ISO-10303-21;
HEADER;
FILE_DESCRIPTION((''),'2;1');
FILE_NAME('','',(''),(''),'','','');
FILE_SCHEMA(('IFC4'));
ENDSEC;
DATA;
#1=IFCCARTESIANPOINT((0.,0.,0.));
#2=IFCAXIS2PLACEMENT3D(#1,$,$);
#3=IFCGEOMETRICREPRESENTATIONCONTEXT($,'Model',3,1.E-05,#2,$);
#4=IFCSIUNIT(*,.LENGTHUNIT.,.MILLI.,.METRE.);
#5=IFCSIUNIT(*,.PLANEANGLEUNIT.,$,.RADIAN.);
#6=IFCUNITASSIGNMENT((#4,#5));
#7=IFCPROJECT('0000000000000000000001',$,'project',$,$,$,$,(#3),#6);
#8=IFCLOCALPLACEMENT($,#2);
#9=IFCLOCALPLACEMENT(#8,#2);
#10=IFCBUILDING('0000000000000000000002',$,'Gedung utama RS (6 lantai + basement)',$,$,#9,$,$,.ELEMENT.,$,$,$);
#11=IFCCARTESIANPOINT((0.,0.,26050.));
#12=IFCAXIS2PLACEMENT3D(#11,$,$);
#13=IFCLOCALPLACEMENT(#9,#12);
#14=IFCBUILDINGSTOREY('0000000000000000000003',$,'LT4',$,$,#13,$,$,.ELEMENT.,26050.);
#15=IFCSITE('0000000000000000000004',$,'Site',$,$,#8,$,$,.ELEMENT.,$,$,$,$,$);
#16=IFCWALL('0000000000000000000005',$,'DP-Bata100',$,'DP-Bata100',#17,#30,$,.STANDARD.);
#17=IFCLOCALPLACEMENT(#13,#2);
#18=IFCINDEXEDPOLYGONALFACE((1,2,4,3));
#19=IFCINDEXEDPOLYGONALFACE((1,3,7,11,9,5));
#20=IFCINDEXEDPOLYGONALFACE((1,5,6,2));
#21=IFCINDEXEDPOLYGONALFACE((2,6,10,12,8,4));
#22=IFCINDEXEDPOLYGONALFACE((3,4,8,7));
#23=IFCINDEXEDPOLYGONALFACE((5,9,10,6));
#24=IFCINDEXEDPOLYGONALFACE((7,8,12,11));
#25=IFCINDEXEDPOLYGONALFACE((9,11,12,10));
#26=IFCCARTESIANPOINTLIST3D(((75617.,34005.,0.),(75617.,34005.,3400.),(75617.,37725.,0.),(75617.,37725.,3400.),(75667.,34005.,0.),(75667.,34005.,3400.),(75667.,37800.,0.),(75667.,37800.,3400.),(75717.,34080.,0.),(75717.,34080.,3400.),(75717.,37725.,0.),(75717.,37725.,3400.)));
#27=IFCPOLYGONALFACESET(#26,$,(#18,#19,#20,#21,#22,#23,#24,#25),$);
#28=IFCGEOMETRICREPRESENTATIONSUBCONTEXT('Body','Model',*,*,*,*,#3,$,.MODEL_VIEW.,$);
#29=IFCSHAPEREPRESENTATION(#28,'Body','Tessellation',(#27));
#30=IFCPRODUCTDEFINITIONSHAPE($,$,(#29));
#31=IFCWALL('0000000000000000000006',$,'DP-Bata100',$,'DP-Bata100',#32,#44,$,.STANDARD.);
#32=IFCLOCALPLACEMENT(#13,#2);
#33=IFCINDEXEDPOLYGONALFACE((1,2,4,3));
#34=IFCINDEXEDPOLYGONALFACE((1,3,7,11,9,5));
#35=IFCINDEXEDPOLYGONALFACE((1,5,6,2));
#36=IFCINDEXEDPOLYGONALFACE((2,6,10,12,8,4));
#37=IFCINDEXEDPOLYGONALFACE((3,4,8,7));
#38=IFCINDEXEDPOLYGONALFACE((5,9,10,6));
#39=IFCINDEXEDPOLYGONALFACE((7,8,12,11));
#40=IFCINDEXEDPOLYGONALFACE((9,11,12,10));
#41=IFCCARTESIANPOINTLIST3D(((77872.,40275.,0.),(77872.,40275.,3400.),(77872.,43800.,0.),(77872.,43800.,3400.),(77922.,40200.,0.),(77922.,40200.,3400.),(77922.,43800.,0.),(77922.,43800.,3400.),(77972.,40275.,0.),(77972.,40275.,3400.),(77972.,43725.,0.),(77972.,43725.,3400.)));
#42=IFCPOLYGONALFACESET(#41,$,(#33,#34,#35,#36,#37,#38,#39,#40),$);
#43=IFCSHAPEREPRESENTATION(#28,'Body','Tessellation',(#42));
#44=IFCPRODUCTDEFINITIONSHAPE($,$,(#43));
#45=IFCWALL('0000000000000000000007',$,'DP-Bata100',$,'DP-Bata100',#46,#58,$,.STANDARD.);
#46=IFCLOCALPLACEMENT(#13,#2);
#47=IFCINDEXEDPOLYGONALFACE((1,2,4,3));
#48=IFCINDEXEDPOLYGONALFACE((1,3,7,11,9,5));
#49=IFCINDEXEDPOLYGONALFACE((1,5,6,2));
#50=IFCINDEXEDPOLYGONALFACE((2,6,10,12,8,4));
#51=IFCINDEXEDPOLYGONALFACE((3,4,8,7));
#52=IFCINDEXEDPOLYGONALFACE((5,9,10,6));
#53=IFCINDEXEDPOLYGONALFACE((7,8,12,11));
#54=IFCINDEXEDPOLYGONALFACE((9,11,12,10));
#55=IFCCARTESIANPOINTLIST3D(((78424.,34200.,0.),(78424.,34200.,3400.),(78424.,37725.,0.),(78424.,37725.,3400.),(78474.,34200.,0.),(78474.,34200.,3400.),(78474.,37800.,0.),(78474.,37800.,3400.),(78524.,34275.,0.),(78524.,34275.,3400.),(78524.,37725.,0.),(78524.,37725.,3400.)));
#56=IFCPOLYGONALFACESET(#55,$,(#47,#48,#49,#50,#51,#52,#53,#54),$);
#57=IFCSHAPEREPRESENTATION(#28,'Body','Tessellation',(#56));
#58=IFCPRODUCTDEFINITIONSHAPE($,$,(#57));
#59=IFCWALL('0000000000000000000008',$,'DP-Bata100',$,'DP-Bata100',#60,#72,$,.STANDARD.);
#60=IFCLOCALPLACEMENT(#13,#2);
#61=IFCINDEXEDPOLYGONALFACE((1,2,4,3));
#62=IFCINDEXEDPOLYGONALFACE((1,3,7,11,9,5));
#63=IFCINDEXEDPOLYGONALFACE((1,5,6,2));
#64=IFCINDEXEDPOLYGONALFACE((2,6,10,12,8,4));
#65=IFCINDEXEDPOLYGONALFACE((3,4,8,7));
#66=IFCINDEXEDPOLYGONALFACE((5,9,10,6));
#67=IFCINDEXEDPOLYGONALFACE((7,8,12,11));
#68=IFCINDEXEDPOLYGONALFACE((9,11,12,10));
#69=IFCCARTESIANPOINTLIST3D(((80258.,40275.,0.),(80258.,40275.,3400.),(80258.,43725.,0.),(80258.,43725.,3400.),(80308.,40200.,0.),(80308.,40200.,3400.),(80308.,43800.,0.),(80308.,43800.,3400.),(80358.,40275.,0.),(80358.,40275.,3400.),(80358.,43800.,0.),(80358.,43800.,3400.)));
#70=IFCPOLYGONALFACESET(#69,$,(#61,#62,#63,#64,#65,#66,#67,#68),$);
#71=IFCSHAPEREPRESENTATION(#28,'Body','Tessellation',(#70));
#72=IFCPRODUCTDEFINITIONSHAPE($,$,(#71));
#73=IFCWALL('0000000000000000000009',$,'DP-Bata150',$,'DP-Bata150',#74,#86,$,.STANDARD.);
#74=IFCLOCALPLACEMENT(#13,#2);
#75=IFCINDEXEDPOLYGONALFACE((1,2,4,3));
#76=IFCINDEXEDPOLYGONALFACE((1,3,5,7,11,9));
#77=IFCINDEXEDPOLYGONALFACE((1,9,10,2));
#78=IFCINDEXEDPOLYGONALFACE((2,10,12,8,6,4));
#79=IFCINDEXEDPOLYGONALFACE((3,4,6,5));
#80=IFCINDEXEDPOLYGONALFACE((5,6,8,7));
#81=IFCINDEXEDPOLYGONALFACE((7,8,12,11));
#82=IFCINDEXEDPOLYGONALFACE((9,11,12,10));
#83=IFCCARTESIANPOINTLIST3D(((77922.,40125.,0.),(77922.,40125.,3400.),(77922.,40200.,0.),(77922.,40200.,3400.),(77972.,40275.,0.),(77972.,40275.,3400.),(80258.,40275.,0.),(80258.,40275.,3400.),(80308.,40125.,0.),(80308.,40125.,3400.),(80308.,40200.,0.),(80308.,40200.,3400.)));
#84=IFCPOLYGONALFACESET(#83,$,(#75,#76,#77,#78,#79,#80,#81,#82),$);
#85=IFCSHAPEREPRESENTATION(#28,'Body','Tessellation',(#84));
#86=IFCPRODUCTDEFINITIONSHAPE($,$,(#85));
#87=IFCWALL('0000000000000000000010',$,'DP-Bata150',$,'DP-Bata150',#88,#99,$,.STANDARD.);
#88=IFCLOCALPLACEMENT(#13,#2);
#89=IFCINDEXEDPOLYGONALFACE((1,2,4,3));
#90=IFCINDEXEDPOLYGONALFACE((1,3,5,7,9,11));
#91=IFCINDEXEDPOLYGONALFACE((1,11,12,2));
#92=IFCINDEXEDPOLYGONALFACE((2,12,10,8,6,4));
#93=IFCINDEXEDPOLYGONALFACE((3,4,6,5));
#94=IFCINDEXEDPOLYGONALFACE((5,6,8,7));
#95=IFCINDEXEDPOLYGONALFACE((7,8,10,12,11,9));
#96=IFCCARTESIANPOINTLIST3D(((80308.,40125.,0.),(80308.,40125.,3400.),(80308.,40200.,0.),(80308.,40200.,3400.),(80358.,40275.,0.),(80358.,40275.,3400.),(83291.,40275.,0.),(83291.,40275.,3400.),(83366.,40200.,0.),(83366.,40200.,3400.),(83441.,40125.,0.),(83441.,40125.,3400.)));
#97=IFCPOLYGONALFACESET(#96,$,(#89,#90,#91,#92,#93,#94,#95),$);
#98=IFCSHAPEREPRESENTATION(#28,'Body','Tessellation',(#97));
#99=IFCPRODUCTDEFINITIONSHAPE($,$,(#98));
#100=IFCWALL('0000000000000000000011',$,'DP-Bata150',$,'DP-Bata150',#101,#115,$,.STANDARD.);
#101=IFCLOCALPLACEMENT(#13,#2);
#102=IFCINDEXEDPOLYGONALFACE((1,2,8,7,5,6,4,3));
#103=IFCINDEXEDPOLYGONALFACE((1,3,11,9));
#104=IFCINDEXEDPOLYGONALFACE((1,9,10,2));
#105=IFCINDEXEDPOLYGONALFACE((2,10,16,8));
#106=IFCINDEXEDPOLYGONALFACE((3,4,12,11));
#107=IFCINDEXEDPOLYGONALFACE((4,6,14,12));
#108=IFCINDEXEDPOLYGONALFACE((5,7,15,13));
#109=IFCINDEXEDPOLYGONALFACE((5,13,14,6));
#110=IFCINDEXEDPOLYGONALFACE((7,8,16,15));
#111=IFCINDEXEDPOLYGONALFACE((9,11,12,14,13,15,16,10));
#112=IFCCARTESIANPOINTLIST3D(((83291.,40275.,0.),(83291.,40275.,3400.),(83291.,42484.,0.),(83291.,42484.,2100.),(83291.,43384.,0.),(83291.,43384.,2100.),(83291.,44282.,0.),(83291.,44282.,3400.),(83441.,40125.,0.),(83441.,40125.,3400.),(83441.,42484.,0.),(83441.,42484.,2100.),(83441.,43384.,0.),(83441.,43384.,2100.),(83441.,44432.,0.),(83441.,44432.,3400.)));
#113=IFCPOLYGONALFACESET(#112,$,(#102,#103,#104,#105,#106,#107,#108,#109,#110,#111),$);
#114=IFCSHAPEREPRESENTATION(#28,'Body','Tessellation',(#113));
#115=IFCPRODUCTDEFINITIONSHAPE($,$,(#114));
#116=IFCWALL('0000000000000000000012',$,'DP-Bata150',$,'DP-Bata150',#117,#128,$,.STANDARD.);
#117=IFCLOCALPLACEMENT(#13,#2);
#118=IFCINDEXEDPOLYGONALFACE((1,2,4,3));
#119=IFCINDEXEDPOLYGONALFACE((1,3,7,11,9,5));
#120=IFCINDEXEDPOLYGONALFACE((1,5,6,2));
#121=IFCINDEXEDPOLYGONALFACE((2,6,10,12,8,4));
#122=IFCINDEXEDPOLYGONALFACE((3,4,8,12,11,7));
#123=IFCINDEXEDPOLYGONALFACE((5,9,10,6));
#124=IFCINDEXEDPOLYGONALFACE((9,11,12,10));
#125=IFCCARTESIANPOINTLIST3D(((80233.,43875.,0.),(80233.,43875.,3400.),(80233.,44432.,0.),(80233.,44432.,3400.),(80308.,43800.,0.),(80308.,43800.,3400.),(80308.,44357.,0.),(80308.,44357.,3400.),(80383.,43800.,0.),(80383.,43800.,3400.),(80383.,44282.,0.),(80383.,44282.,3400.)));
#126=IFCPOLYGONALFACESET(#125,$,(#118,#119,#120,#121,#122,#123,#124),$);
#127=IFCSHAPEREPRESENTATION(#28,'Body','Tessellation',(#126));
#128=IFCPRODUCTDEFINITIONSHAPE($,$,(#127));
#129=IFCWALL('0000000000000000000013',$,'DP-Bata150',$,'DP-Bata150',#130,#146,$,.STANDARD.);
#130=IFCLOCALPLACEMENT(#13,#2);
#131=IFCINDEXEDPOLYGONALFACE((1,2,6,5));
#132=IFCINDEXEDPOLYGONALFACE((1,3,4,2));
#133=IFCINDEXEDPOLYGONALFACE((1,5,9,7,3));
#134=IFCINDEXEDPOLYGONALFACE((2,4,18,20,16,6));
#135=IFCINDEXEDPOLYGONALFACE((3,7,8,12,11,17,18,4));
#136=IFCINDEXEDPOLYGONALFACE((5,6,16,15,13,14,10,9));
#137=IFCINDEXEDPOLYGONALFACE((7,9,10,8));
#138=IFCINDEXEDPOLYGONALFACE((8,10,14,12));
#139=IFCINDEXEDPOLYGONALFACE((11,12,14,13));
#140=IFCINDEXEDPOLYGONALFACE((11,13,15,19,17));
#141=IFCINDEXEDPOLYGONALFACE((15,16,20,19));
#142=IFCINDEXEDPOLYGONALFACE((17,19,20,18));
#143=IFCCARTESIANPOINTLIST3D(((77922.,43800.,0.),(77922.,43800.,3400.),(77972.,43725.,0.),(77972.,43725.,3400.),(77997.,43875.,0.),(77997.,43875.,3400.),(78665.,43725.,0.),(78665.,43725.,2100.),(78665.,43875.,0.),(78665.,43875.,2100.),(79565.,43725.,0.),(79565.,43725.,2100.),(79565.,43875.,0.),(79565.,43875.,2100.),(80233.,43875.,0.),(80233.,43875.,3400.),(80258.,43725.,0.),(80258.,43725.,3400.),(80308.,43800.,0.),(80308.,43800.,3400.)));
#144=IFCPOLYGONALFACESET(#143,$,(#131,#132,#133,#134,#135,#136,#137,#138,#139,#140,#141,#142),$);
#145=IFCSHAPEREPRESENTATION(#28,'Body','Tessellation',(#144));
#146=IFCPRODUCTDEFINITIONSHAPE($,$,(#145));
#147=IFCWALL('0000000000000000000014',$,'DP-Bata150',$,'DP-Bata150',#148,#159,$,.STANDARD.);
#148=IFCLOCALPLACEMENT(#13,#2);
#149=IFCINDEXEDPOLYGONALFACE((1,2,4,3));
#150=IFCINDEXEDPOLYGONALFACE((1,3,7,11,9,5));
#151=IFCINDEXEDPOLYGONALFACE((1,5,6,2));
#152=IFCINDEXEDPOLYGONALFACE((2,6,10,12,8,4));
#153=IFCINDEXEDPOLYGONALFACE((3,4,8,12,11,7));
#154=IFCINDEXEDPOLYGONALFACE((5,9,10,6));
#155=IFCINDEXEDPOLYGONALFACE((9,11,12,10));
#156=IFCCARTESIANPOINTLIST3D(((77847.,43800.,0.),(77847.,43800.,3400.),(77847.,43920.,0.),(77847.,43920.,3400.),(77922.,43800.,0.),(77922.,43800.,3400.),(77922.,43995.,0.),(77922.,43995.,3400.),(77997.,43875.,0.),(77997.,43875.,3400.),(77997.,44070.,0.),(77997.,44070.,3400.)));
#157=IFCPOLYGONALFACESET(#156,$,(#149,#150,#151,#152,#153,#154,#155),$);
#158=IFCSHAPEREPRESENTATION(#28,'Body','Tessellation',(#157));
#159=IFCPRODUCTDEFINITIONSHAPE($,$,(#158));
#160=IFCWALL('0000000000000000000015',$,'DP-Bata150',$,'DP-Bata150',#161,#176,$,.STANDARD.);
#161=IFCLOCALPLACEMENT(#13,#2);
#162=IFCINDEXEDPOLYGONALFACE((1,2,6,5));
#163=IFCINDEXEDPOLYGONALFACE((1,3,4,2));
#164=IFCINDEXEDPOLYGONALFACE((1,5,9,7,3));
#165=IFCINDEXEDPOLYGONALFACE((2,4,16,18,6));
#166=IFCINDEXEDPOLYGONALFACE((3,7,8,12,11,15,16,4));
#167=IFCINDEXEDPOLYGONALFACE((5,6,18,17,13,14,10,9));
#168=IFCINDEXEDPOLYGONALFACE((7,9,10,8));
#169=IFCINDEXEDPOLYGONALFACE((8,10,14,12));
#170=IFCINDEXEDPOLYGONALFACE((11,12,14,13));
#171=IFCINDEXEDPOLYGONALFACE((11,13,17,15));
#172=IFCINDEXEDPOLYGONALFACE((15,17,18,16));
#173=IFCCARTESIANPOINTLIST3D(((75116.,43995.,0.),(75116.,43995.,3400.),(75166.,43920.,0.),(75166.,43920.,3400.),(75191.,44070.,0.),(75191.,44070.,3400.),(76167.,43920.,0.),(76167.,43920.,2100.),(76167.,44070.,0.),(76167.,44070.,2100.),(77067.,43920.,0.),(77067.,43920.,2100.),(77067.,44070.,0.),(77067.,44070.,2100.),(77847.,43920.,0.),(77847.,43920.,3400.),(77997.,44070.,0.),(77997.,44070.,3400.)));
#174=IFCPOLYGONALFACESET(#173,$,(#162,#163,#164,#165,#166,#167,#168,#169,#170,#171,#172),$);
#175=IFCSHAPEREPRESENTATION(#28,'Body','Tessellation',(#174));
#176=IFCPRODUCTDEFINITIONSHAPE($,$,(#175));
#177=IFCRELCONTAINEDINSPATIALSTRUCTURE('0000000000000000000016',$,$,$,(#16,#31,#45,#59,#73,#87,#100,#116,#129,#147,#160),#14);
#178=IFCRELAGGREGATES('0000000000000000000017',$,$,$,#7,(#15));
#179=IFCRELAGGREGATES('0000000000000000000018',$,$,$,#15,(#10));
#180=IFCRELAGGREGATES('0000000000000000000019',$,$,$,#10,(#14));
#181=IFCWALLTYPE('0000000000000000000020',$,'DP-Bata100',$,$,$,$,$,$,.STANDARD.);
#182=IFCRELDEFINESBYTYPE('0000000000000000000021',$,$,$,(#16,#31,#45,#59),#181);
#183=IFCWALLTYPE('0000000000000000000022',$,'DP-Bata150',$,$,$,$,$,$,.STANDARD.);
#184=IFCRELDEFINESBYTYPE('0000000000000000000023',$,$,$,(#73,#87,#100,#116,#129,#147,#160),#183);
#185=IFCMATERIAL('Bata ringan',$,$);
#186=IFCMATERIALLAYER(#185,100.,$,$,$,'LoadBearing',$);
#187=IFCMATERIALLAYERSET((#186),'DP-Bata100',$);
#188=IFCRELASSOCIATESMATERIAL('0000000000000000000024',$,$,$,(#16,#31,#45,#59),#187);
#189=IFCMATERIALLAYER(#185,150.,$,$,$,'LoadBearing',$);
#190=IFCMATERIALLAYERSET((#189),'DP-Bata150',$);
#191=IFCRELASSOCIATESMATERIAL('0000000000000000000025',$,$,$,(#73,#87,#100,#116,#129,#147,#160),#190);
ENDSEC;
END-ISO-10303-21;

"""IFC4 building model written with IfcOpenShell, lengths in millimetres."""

from ifc_helpers import new_model, si_unit, frame, frame_2d, origin, place, context, subcontext, project, spatial, polyline, rectangle, outline, extrude, material, layer, layer_set, layer_usage, type_object, element, save


model = new_model("IFC4")

# Units and contexts
model_context = context("Model", 3, precision=1e-05, world=origin())
body_context = subcontext(model_context, "Body", "Model", "MODEL_VIEW")
ifc_project = project(units=[si_unit("LENGTHUNIT", "METRE", prefix="MILLI"), si_unit("PLANEANGLEUNIT", "RADIAN")], contexts=[model_context])

# Site, building, storey
site_placement = place(None, origin())
site = spatial("IfcSite", under=ifc_project, at=site_placement, Name="Site", CompositionType="ELEMENT")
building_placement = place(site_placement, origin())
building = spatial("IfcBuilding", under=site, at=building_placement, Name="Gedung utama RS (6 lantai + basement)", CompositionType="ELEMENT")
storey_placement = place(building_placement, frame((0.0, 0.0, 26050.0)))
storey = spatial("IfcBuildingStorey", under=building, at=storey_placement, Name="LT4", CompositionType="ELEMENT", Elevation=26050.0)

# Walls
ifc_material = material(Name="Bata ringan")
ifc_layer_1 = layer(ifc_material, 100.0, Category="LoadBearing")
ifc_layer_set_1 = layer_set([ifc_layer_1], Name="DP-Bata100")
ifc_layer_usage_1 = layer_usage(ifc_layer_set_1, "AXIS2", "NEGATIVE", 50.0)
wall_type_1 = type_object("IfcWallType", Name="DP-Bata100", PredefinedType="STANDARD")
wall_1_placement = place(storey_placement, frame((75667.0, 37800.0, 0.0), z_axis=(0.0, 0.0, 1.0), x_axis=(0.0, -1.0, 0.0)))
element("IfcWall", 1, at=wall_1_placement, inside=storey, type_object=wall_type_1, material=ifc_layer_usage_1, Name="DP-Bata100", ObjectType="DP-Bata100", PredefinedType="STANDARD", context=body_context, shape_type="SweptSolid", body=[
    extrude(outline(polyline([(75.0, -50.0), (0.0, 0.0), (75.0, 50.0), (3720.0, 50.0), (3795.0, 0.0), (3795.0, -50.0), (75.0, -50.0)])), origin(), (0.0, 0.0, 1.0), 3400.0),
])
wall_2_placement = place(storey_placement, frame((77922.0, 40200.0, 0.0), z_axis=(0.0, 0.0, 1.0), x_axis=(0.0, 1.0, 0.0)))
element("IfcWall", 2, at=wall_2_placement, inside=storey, type_object=wall_type_1, material=ifc_layer_usage_1, Name="DP-Bata100", ObjectType="DP-Bata100", PredefinedType="STANDARD", context=body_context, shape_type="SweptSolid", body=[
    extrude(outline(polyline([(75.0, -50.0), (0.0, 0.0), (75.0, 50.0), (3600.0, 50.0), (3600.0, 0.0), (3525.0, -50.0), (75.0, -50.0)])), origin(), (0.0, 0.0, 1.0), 3400.0),
])
wall_3_placement = place(storey_placement, frame((78474.0, 34200.0, 0.0), z_axis=(0.0, 0.0, 1.0), x_axis=(0.0, 1.0, 0.0)))
element("IfcWall", 3, at=wall_3_placement, inside=storey, type_object=wall_type_1, material=ifc_layer_usage_1, Name="DP-Bata100", ObjectType="DP-Bata100", PredefinedType="STANDARD", context=body_context, shape_type="SweptSolid", body=[
    extrude(outline(polyline([(75.0, -50.0), (0.0, 0.0), (0.0, 50.0), (3525.0, 50.0), (3600.0, 0.0), (3525.0, -50.0), (75.0, -50.0)])), origin(), (0.0, 0.0, 1.0), 3400.0),
])
wall_4_placement = place(storey_placement, frame((80308.0, 40200.0, 0.0), z_axis=(0.0, 0.0, 1.0), x_axis=(0.0, 1.0, 0.0)))
element("IfcWall", 4, at=wall_4_placement, inside=storey, type_object=wall_type_1, material=ifc_layer_usage_1, Name="DP-Bata100", ObjectType="DP-Bata100", PredefinedType="STANDARD", context=body_context, shape_type="SweptSolid", body=[
    extrude(outline(polyline([(75.0, -50.0), (0.0, 0.0), (75.0, 50.0), (3525.0, 50.0), (3600.0, 0.0), (3600.0, -50.0), (75.0, -50.0)])), origin(), (0.0, 0.0, 1.0), 3400.0),
])
ifc_layer_2 = layer(ifc_material, 150.0, Category="LoadBearing")
ifc_layer_set_2 = layer_set([ifc_layer_2], Name="DP-Bata150")
ifc_layer_usage_2 = layer_usage(ifc_layer_set_2, "AXIS2", "NEGATIVE", 75.0)
wall_type_2 = type_object("IfcWallType", Name="DP-Bata150", PredefinedType="STANDARD")
wall_5_placement = place(storey_placement, frame((77922.0, 40200.0, 0.0), z_axis=(0.0, 0.0, 1.0), x_axis=(1.0, 0.0, 0.0)))
element("IfcWall", 5, at=wall_5_placement, inside=storey, type_object=wall_type_2, material=ifc_layer_usage_2, Name="DP-Bata150", ObjectType="DP-Bata150", PredefinedType="STANDARD", context=body_context, shape_type="SweptSolid", body=[
    extrude(outline(polyline([(0.0, -75.0), (0.0, 0.0), (50.0, 75.0), (2336.0, 75.0), (2386.0, 0.0), (2386.0, -75.0), (0.0, -75.0)])), origin(), (0.0, 0.0, 1.0), 3400.0),
])
wall_6_placement = place(storey_placement, frame((80308.0, 40200.0, 0.0), z_axis=(0.0, 0.0, 1.0), x_axis=(1.0, 0.0, 0.0)))
element("IfcWall", 6, at=wall_6_placement, inside=storey, type_object=wall_type_2, material=ifc_layer_usage_2, Name="DP-Bata150", ObjectType="DP-Bata150", PredefinedType="STANDARD", context=body_context, shape_type="SweptSolid", body=[
    extrude(outline(polyline([(0.0, -75.0), (0.0, 0.0), (50.0, 75.0), (2983.0, 75.0), (3058.0, 0.0), (3133.0, -75.0), (0.0, -75.0)])), origin(), (0.0, 0.0, 1.0), 3400.0),
])

# Wall, opening
wall_7_placement = place(storey_placement, frame((83366.0, 40200.0, 0.0), z_axis=(0.0, 0.0, 1.0), x_axis=(0.0, 1.0, 0.0)))
wall_7 = element("IfcWall", 7, at=wall_7_placement, inside=storey, type_object=wall_type_2, material=ifc_layer_usage_2, Name="DP-Bata150", ObjectType="DP-Bata150", PredefinedType="STANDARD", context=body_context, shape_type="SweptSolid", body=[
    extrude(outline(polyline([(-75.0, -75.0), (0.0, 0.0), (75.0, 75.0), (4082.0, 75.0), (4157.0, 0.0), (4232.0, -75.0), (-75.0, -75.0)])), origin(), (0.0, 0.0, 1.0), 3400.0),
])
opening_1_placement = place(wall_7_placement, frame((2284.0, 0.0, 0.0), z_axis=(0.0, 0.0, 1.0), x_axis=(1.0, 0.0, 0.0)))
element("IfcOpeningElement", 8, at=opening_1_placement, cuts=wall_7, PredefinedType="OPENING", context=body_context, shape_type="SweptSolid", body=[
    extrude(rectangle(XDim=900.0, YDim=170.0, at=frame_2d((450.0, 0.0))), origin(), (0.0, 0.0, 1.0), 2100.0),
])

# Wall
wall_8_placement = place(storey_placement, frame((80308.0, 44357.0, 0.0), z_axis=(0.0, 0.0, 1.0), x_axis=(0.0, -1.0, 0.0)))
element("IfcWall", 9, at=wall_8_placement, inside=storey, type_object=wall_type_2, material=ifc_layer_usage_2, Name="DP-Bata150", ObjectType="DP-Bata150", PredefinedType="STANDARD", context=body_context, shape_type="SweptSolid", body=[
    extrude(outline(polyline([(-75.0, -75.0), (0.0, 0.0), (75.0, 75.0), (557.0, 75.0), (557.0, 0.0), (482.0, -75.0), (-75.0, -75.0)])), origin(), (0.0, 0.0, 1.0), 3400.0),
])

# Wall, opening
wall_9_placement = place(storey_placement, frame((80308.0, 43800.0, 0.0), z_axis=(0.0, 0.0, 1.0), x_axis=(-1.0, 0.0, 0.0)))
wall_9 = element("IfcWall", 10, at=wall_9_placement, inside=storey, type_object=wall_type_2, material=ifc_layer_usage_2, Name="DP-Bata150", ObjectType="DP-Bata150", PredefinedType="STANDARD", context=body_context, shape_type="SweptSolid", body=[
    extrude(outline(polyline([(75.0, -75.0), (0.0, 0.0), (50.0, 75.0), (2336.0, 75.0), (2386.0, 0.0), (2311.0, -75.0), (75.0, -75.0)])), origin(), (0.0, 0.0, 1.0), 3400.0),
])
opening_2_placement = place(wall_9_placement, frame((743.0, 0.0, 0.0), z_axis=(0.0, 0.0, 1.0), x_axis=(1.0, 0.0, 0.0)))
element("IfcOpeningElement", 11, at=opening_2_placement, cuts=wall_9, PredefinedType="OPENING", context=body_context, shape_type="SweptSolid", body=[
    extrude(rectangle(XDim=900.0, YDim=170.0, at=frame_2d((450.0, 0.0))), origin(), (0.0, 0.0, 1.0), 2100.0),
])

# Wall
wall_10_placement = place(storey_placement, frame((77922.0, 43800.0, 0.0), z_axis=(0.0, 0.0, 1.0), x_axis=(0.0, 1.0, 0.0)))
element("IfcWall", 12, at=wall_10_placement, inside=storey, type_object=wall_type_2, material=ifc_layer_usage_2, Name="DP-Bata150", ObjectType="DP-Bata150", PredefinedType="STANDARD", context=body_context, shape_type="SweptSolid", body=[
    extrude(outline(polyline([(75.0, -75.0), (0.0, 0.0), (0.0, 75.0), (120.0, 75.0), (195.0, 0.0), (270.0, -75.0), (75.0, -75.0)])), origin(), (0.0, 0.0, 1.0), 3400.0),
])

# Wall, opening
wall_11_placement = place(storey_placement, frame((77922.0, 43995.0, 0.0), z_axis=(0.0, 0.0, 1.0), x_axis=(-1.0, 0.0, 0.0)))
wall_11 = element("IfcWall", 13, at=wall_11_placement, inside=storey, type_object=wall_type_2, material=ifc_layer_usage_2, Name="DP-Bata150", ObjectType="DP-Bata150", PredefinedType="STANDARD", context=body_context, shape_type="SweptSolid", body=[
    extrude(outline(polyline([(-75.0, -75.0), (0.0, 0.0), (75.0, 75.0), (2756.0, 75.0), (2806.0, 0.0), (2731.0, -75.0), (-75.0, -75.0)])), origin(), (0.0, 0.0, 1.0), 3400.0),
])
opening_3_placement = place(wall_11_placement, frame((855.0, 0.0, 0.0), z_axis=(0.0, 0.0, 1.0), x_axis=(1.0, 0.0, 0.0)))
element("IfcOpeningElement", 14, at=opening_3_placement, cuts=wall_11, PredefinedType="OPENING", context=body_context, shape_type="SweptSolid", body=[
    extrude(rectangle(XDim=900.0, YDim=170.0, at=frame_2d((450.0, 0.0))), origin(), (0.0, 0.0, 1.0), 2100.0),
])

save(model, "model.ifc")
